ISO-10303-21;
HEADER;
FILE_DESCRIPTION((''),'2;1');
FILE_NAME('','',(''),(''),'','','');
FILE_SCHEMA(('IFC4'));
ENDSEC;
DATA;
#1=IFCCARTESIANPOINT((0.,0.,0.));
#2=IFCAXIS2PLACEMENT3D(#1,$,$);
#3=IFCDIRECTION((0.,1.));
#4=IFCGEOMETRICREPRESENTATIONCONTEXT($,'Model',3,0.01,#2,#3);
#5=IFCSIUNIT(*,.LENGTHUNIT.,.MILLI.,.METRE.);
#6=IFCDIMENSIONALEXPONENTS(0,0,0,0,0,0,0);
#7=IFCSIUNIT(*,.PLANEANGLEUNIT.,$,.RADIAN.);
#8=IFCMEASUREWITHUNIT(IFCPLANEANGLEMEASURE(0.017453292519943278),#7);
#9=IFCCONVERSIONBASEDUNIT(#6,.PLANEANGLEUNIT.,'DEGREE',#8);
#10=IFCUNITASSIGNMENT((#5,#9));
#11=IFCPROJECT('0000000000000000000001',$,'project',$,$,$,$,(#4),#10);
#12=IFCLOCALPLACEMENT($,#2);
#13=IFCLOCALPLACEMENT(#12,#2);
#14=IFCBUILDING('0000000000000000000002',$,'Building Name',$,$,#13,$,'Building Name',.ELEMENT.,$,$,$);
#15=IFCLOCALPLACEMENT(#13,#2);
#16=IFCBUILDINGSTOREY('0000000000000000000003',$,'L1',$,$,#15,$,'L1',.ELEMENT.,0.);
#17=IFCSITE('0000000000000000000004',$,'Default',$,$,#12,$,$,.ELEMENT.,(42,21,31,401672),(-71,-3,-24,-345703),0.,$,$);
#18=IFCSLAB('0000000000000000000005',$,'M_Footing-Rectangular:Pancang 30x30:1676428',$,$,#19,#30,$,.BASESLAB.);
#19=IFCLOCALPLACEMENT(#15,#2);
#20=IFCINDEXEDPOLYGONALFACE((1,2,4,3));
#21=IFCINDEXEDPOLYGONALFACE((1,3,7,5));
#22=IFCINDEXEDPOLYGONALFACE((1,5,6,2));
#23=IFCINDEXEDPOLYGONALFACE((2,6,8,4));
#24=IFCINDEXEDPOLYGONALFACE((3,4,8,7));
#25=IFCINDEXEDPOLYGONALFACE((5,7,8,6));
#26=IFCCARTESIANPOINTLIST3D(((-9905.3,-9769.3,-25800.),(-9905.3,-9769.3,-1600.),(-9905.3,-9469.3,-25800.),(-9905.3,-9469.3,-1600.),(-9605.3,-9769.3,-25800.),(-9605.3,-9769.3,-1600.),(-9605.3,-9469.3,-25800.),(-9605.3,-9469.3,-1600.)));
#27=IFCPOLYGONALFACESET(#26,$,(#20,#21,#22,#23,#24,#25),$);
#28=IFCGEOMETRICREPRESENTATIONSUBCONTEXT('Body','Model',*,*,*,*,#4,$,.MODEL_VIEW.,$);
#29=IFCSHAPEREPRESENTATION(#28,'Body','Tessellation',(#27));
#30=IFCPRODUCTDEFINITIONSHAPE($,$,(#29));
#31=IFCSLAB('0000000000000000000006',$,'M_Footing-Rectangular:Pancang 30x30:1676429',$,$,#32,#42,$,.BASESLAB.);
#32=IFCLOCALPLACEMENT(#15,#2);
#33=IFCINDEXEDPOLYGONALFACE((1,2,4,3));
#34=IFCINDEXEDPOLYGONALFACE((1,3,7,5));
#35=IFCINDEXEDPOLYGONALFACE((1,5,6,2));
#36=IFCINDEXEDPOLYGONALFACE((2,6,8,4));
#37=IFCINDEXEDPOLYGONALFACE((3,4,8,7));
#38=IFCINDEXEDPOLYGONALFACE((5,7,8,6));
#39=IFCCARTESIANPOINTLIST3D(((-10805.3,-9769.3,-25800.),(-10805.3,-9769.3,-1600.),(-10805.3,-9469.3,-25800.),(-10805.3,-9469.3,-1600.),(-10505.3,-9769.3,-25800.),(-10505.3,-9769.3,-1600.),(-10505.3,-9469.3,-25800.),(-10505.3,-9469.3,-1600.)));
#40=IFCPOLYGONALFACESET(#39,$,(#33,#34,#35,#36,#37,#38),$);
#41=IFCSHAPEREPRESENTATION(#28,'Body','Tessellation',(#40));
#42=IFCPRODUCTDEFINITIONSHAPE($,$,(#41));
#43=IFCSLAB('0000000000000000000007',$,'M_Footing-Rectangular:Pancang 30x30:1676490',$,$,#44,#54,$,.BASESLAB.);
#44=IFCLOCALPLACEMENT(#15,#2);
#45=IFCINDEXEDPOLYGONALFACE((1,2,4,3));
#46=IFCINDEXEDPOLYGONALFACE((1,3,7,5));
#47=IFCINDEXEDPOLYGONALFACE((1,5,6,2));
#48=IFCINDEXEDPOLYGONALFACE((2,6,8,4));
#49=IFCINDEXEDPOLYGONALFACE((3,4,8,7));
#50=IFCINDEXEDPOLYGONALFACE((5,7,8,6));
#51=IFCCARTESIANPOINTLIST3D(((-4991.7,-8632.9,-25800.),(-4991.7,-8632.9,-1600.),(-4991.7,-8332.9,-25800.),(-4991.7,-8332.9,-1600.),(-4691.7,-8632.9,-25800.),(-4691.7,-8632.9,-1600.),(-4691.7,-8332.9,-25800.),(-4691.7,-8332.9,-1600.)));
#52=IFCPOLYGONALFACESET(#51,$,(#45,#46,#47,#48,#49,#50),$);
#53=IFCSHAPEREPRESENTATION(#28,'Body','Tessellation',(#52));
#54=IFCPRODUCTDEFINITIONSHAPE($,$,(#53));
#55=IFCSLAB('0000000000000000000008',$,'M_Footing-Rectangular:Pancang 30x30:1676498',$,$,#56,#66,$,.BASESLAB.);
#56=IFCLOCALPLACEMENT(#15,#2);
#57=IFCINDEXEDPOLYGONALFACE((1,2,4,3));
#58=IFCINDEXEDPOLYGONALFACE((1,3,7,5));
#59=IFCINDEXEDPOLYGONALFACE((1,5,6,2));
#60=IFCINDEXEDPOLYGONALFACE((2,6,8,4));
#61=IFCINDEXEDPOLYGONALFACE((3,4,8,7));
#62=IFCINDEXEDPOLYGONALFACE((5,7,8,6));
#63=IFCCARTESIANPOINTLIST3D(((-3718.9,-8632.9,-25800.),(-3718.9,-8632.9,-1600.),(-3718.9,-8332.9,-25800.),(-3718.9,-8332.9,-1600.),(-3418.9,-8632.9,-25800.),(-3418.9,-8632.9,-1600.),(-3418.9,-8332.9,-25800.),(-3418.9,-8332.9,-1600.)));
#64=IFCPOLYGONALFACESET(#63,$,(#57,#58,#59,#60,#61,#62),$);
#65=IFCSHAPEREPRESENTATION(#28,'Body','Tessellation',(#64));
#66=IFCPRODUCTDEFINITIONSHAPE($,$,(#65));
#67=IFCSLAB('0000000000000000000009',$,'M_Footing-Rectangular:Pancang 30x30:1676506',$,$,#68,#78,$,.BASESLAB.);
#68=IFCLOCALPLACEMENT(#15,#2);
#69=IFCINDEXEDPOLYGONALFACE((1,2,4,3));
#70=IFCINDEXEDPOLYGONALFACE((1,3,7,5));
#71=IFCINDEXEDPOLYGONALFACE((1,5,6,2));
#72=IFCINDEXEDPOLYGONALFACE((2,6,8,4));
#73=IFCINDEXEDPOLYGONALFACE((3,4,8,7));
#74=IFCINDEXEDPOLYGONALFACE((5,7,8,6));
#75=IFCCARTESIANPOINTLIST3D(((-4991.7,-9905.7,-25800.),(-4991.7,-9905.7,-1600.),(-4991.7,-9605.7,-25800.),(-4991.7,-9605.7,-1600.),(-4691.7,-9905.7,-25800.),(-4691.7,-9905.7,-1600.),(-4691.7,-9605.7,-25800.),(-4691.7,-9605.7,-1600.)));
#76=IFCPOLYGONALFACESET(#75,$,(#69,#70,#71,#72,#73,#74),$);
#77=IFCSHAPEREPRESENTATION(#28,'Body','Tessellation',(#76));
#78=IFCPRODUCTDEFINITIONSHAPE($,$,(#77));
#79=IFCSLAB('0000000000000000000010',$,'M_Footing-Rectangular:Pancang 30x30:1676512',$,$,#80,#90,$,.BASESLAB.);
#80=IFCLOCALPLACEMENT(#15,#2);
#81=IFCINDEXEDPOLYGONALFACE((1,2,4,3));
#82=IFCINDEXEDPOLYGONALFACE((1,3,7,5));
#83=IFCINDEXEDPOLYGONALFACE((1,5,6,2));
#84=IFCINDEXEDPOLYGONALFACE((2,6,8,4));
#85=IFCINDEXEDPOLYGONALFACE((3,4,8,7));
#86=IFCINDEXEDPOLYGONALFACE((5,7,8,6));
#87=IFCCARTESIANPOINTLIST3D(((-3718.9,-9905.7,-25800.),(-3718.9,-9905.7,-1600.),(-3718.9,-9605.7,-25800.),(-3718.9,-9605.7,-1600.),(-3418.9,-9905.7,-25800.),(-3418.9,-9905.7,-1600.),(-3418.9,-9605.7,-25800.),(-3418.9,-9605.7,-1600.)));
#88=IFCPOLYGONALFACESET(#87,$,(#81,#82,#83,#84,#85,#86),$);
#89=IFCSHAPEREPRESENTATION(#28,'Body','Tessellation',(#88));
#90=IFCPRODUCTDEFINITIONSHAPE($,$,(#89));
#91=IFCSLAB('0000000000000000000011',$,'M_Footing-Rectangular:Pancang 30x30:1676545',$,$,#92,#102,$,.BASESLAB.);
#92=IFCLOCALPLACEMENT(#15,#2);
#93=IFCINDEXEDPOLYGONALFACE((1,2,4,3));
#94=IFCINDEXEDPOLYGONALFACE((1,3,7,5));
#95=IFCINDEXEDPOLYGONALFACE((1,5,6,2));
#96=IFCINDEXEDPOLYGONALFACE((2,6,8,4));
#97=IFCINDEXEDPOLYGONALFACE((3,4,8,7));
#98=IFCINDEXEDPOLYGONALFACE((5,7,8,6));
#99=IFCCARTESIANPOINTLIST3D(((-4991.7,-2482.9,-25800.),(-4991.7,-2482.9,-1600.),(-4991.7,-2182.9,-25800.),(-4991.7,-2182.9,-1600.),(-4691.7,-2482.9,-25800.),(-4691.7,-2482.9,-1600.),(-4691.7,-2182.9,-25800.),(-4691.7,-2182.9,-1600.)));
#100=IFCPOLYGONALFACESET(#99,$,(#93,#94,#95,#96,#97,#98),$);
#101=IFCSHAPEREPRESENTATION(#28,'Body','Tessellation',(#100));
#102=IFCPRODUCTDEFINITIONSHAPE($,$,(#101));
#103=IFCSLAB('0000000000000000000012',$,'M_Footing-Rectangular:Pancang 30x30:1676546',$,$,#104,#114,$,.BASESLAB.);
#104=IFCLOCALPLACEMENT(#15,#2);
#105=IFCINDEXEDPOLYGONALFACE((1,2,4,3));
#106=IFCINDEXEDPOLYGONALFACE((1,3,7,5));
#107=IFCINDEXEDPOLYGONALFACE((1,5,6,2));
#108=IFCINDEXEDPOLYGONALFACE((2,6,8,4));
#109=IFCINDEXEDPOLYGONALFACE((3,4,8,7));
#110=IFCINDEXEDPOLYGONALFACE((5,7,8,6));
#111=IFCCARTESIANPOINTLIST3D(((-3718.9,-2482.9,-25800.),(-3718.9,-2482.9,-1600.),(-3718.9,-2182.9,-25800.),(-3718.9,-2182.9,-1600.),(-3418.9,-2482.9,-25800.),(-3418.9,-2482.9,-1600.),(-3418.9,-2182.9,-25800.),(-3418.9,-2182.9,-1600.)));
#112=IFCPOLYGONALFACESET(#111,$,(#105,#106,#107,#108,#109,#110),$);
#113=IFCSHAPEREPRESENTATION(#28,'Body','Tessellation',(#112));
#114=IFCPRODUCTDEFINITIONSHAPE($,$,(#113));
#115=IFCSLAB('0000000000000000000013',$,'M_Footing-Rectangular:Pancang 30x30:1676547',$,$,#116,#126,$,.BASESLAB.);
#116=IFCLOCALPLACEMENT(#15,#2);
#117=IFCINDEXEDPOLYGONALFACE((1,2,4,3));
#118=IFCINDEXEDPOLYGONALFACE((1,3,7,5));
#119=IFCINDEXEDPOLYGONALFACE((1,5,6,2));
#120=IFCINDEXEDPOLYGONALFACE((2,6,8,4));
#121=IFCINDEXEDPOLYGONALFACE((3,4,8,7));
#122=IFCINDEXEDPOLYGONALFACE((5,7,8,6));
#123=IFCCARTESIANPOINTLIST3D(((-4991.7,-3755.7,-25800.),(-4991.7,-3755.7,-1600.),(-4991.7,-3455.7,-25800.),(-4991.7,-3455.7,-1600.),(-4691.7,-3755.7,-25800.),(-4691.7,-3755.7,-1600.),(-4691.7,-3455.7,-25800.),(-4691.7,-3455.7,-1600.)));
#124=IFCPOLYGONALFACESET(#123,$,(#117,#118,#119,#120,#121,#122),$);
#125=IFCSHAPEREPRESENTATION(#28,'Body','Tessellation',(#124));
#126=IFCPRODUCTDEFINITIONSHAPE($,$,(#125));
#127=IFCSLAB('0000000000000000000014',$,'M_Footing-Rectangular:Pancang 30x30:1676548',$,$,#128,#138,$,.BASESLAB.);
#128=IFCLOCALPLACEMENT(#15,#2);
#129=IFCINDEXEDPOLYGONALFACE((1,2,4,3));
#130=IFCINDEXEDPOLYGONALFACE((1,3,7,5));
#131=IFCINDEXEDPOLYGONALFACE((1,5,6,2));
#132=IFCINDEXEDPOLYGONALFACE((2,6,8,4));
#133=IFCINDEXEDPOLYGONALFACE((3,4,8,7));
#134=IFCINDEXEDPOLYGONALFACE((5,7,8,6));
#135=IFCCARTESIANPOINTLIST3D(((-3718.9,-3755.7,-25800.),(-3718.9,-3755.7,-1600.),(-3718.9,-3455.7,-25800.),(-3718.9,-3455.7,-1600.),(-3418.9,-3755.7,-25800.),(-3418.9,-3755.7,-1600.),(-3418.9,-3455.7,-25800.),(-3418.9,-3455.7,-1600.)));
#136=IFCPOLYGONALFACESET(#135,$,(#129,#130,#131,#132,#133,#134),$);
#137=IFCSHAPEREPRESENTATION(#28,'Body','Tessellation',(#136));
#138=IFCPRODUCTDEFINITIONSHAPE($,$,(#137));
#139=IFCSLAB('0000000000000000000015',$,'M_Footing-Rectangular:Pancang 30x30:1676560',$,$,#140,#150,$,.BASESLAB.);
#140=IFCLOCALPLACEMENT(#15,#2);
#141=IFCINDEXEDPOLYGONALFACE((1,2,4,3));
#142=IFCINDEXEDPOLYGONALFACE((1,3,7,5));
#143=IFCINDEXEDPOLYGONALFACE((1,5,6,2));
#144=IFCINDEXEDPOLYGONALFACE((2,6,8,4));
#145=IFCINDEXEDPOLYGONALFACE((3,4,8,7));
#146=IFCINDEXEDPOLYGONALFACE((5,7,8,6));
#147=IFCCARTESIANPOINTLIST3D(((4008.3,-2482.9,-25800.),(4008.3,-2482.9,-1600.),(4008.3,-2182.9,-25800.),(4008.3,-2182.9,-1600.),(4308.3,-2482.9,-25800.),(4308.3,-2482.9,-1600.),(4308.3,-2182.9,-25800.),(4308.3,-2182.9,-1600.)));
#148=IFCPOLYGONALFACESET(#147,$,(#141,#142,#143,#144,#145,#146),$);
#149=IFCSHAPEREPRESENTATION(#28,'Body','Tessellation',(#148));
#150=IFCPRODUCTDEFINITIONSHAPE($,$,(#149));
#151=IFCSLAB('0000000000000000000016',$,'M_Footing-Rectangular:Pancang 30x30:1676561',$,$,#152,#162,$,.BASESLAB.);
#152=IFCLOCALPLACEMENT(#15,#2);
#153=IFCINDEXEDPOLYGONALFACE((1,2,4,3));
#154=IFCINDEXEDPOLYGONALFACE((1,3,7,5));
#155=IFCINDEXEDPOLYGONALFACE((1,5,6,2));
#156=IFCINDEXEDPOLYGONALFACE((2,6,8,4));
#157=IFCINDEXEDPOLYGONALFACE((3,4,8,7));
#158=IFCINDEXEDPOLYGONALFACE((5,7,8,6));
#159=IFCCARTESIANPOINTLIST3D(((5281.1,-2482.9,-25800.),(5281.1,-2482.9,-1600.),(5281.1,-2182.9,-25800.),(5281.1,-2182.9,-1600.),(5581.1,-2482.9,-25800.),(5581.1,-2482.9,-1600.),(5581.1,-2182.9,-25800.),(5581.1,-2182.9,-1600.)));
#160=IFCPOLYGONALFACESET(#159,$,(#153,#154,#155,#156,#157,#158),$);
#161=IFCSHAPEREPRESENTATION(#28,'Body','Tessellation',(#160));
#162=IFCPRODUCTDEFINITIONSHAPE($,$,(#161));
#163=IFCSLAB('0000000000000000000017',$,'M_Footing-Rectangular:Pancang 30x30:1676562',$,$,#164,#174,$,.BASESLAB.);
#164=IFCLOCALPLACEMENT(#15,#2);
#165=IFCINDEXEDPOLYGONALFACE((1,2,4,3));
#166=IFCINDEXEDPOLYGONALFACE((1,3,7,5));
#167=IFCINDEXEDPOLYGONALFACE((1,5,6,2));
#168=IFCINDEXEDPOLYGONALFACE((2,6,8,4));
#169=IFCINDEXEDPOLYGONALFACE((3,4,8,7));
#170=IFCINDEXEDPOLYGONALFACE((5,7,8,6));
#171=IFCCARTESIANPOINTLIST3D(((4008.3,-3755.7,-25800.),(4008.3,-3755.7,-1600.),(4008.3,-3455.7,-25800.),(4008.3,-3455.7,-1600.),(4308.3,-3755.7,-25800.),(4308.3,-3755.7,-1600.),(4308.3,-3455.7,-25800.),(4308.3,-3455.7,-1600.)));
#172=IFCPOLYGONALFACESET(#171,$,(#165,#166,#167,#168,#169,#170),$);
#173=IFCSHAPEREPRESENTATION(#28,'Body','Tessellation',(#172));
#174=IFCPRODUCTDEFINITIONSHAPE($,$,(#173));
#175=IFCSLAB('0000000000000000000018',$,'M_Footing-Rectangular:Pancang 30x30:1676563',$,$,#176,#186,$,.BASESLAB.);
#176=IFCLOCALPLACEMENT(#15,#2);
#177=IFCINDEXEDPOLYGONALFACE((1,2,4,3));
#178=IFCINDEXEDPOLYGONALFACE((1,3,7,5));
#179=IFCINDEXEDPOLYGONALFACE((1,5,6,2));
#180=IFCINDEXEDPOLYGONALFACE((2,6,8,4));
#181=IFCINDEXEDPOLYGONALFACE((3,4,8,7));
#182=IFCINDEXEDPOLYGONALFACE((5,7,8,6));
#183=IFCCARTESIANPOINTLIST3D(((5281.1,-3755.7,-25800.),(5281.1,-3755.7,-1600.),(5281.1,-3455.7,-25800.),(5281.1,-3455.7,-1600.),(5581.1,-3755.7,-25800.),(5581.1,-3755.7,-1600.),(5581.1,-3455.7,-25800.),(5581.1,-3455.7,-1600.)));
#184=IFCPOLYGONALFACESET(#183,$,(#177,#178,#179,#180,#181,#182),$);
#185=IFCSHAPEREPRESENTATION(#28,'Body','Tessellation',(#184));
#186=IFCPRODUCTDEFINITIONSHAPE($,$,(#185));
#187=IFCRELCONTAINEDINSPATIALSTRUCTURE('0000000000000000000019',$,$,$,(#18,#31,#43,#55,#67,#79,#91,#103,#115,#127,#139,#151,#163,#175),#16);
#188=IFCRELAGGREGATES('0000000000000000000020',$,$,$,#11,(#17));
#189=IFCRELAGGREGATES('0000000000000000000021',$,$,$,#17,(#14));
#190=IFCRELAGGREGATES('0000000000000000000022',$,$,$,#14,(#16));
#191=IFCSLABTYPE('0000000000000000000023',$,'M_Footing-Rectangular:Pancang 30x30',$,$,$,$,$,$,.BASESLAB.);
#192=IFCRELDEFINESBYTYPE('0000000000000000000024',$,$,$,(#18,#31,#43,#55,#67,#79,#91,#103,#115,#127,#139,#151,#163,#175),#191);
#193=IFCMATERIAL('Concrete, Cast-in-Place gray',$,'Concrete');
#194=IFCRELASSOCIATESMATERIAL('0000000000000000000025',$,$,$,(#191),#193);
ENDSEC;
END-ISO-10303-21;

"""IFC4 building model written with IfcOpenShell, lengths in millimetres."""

from ifc_helpers import new_model, entity, si_unit, converted_unit, direction, frame, origin, place, context, subcontext, project, spatial, indexed_curve, outline, extrude, material, type_object, element, save


model = new_model("IFC4")

# Units and contexts
model_context = context("Model", 3, precision=0.01, world=origin(), true_north=direction((0.0, 1.0)))
body_context = subcontext(model_context, "Body", "Model", "MODEL_VIEW")
ifc_project = project(units=[si_unit("LENGTHUNIT", "METRE", prefix="MILLI"), converted_unit("PLANEANGLEUNIT", "DEGREE", entity("IfcPlaneAngleMeasure", 0.017453292519943278), si_unit("PLANEANGLEUNIT", "RADIAN"), dimensions=[0, 0, 0, 0, 0, 0, 0])], contexts=[model_context])

# Site, building, storey
site_placement = place(None, origin())
site = spatial("IfcSite", under=ifc_project, at=site_placement, Name="Default", CompositionType="ELEMENT", RefLatitude=(42, 21, 31, 401672), RefLongitude=(-71, -3, -24, -345703), RefElevation=0.0)
building_placement = place(site_placement, origin())
building = spatial("IfcBuilding", under=site, at=building_placement, Name="Building Name", LongName="Building Name", CompositionType="ELEMENT")
storey_placement = place(building_placement, origin())
storey = spatial("IfcBuildingStorey", under=building, at=storey_placement, Name="L1", LongName="L1", CompositionType="ELEMENT", Elevation=0.0)

# Slabs
ifc_material = material(Name="Concrete, Cast-in-Place gray", Category="Concrete")
slab_type = type_object("IfcSlabType", Name="M_Footing-Rectangular:Pancang 30x30", PredefinedType="BASESLAB", material=ifc_material)
slab_1_placement = place(storey_placement, origin())
element("IfcSlab", 1, at=slab_1_placement, inside=storey, type_object=slab_type, Name="M_Footing-Rectangular:Pancang 30x30:1676428", PredefinedType="BASESLAB", context=body_context, shape_type="SweptSolid", body=[
    extrude(outline(indexed_curve([(-150.0, -150.0), (150.0, -150.0), (150.0, 150.0), (-150.0, 150.0), (-150.0, -150.0)], self_intersect=False)), frame((-9755.3, -9619.3, -25800.0), z_axis=(0.0, 0.0, 1.0), x_axis=(-1.0, 0.0, 0.0)), (0.0, 0.0, 1.0), 24200.0),
])
slab_2_placement = place(storey_placement, origin())
element("IfcSlab", 2, at=slab_2_placement, inside=storey, type_object=slab_type, Name="M_Footing-Rectangular:Pancang 30x30:1676429", PredefinedType="BASESLAB", context=body_context, shape_type="SweptSolid", body=[
    extrude(outline(indexed_curve([(-150.0, -150.0), (150.0, -150.0), (150.0, 150.0), (-150.0, 150.0), (-150.0, -150.0)], self_intersect=False)), frame((-10655.3, -9619.3, -25800.0), z_axis=(0.0, 0.0, 1.0), x_axis=(-1.0, 0.0, 0.0)), (0.0, 0.0, 1.0), 24200.0),
])
slab_3_placement = place(storey_placement, origin())
element("IfcSlab", 3, at=slab_3_placement, inside=storey, type_object=slab_type, Name="M_Footing-Rectangular:Pancang 30x30:1676490", PredefinedType="BASESLAB", context=body_context, shape_type="SweptSolid", body=[
    extrude(outline(indexed_curve([(-150.0, -150.0), (150.0, -150.0), (150.0, 150.0), (-150.0, 150.0), (-150.0, -150.0)], self_intersect=False)), frame((-4841.7, -8482.9, -25800.0), z_axis=(0.0, 0.0, 1.0), x_axis=(-1.0, 0.0, 0.0)), (0.0, 0.0, 1.0), 24200.0),
])
slab_4_placement = place(storey_placement, origin())
element("IfcSlab", 4, at=slab_4_placement, inside=storey, type_object=slab_type, Name="M_Footing-Rectangular:Pancang 30x30:1676498", PredefinedType="BASESLAB", context=body_context, shape_type="SweptSolid", body=[
    extrude(outline(indexed_curve([(-150.0, -150.0), (150.0, -150.0), (150.0, 150.0), (-150.0, 150.0), (-150.0, -150.0)], self_intersect=False)), frame((-3568.9, -8482.9, -25800.0), z_axis=(0.0, 0.0, 1.0), x_axis=(-1.0, 0.0, 0.0)), (0.0, 0.0, 1.0), 24200.0),
])
slab_5_placement = place(storey_placement, origin())
element("IfcSlab", 5, at=slab_5_placement, inside=storey, type_object=slab_type, Name="M_Footing-Rectangular:Pancang 30x30:1676506", PredefinedType="BASESLAB", context=body_context, shape_type="SweptSolid", body=[
    extrude(outline(indexed_curve([(-150.0, -150.0), (150.0, -150.0), (150.0, 150.0), (-150.0, 150.0), (-150.0, -150.0)], self_intersect=False)), frame((-4841.7, -9755.7, -25800.0), z_axis=(0.0, 0.0, 1.0), x_axis=(-1.0, 0.0, 0.0)), (0.0, 0.0, 1.0), 24200.0),
])
slab_6_placement = place(storey_placement, origin())
element("IfcSlab", 6, at=slab_6_placement, inside=storey, type_object=slab_type, Name="M_Footing-Rectangular:Pancang 30x30:1676512", PredefinedType="BASESLAB", context=body_context, shape_type="SweptSolid", body=[
    extrude(outline(indexed_curve([(-150.0, -150.0), (150.0, -150.0), (150.0, 150.0), (-150.0, 150.0), (-150.0, -150.0)], self_intersect=False)), frame((-3568.9, -9755.7, -25800.0), z_axis=(0.0, 0.0, 1.0), x_axis=(-1.0, 0.0, 0.0)), (0.0, 0.0, 1.0), 24200.0),
])
slab_7_placement = place(storey_placement, origin())
element("IfcSlab", 7, at=slab_7_placement, inside=storey, type_object=slab_type, Name="M_Footing-Rectangular:Pancang 30x30:1676545", PredefinedType="BASESLAB", context=body_context, shape_type="SweptSolid", body=[
    extrude(outline(indexed_curve([(-150.0, -150.0), (150.0, -150.0), (150.0, 150.0), (-150.0, 150.0), (-150.0, -150.0)], self_intersect=False)), frame((-4841.7, -2332.9, -25800.0), z_axis=(0.0, 0.0, 1.0), x_axis=(-1.0, 0.0, 0.0)), (0.0, 0.0, 1.0), 24200.0),
])
slab_8_placement = place(storey_placement, origin())
element("IfcSlab", 8, at=slab_8_placement, inside=storey, type_object=slab_type, Name="M_Footing-Rectangular:Pancang 30x30:1676546", PredefinedType="BASESLAB", context=body_context, shape_type="SweptSolid", body=[
    extrude(outline(indexed_curve([(-150.0, -150.0), (150.0, -150.0), (150.0, 150.0), (-150.0, 150.0), (-150.0, -150.0)], self_intersect=False)), frame((-3568.9, -2332.9, -25800.0), z_axis=(0.0, 0.0, 1.0), x_axis=(-1.0, 0.0, 0.0)), (0.0, 0.0, 1.0), 24200.0),
])
slab_9_placement = place(storey_placement, origin())
element("IfcSlab", 9, at=slab_9_placement, inside=storey, type_object=slab_type, Name="M_Footing-Rectangular:Pancang 30x30:1676547", PredefinedType="BASESLAB", context=body_context, shape_type="SweptSolid", body=[
    extrude(outline(indexed_curve([(-150.0, -150.0), (150.0, -150.0), (150.0, 150.0), (-150.0, 150.0), (-150.0, -150.0)], self_intersect=False)), frame((-4841.7, -3605.7, -25800.0), z_axis=(0.0, 0.0, 1.0), x_axis=(-1.0, 0.0, 0.0)), (0.0, 0.0, 1.0), 24200.0),
])
slab_10_placement = place(storey_placement, origin())
element("IfcSlab", 10, at=slab_10_placement, inside=storey, type_object=slab_type, Name="M_Footing-Rectangular:Pancang 30x30:1676548", PredefinedType="BASESLAB", context=body_context, shape_type="SweptSolid", body=[
    extrude(outline(indexed_curve([(-150.0, -150.0), (150.0, -150.0), (150.0, 150.0), (-150.0, 150.0), (-150.0, -150.0)], self_intersect=False)), frame((-3568.9, -3605.7, -25800.0), z_axis=(0.0, 0.0, 1.0), x_axis=(-1.0, 0.0, 0.0)), (0.0, 0.0, 1.0), 24200.0),
])
slab_11_placement = place(storey_placement, origin())
element("IfcSlab", 11, at=slab_11_placement, inside=storey, type_object=slab_type, Name="M_Footing-Rectangular:Pancang 30x30:1676560", PredefinedType="BASESLAB", context=body_context, shape_type="SweptSolid", body=[
    extrude(outline(indexed_curve([(-150.0, -150.0), (150.0, -150.0), (150.0, 150.0), (-150.0, 150.0), (-150.0, -150.0)], self_intersect=False)), frame((4158.3, -2332.9, -25800.0), z_axis=(0.0, 0.0, 1.0), x_axis=(-1.0, 0.0, 0.0)), (0.0, 0.0, 1.0), 24200.0),
])
slab_12_placement = place(storey_placement, origin())
element("IfcSlab", 12, at=slab_12_placement, inside=storey, type_object=slab_type, Name="M_Footing-Rectangular:Pancang 30x30:1676561", PredefinedType="BASESLAB", context=body_context, shape_type="SweptSolid", body=[
    extrude(outline(indexed_curve([(-150.0, -150.0), (150.0, -150.0), (150.0, 150.0), (-150.0, 150.0), (-150.0, -150.0)], self_intersect=False)), frame((5431.1, -2332.9, -25800.0), z_axis=(0.0, 0.0, 1.0), x_axis=(-1.0, 0.0, 0.0)), (0.0, 0.0, 1.0), 24200.0),
])
slab_13_placement = place(storey_placement, origin())
element("IfcSlab", 13, at=slab_13_placement, inside=storey, type_object=slab_type, Name="M_Footing-Rectangular:Pancang 30x30:1676562", PredefinedType="BASESLAB", context=body_context, shape_type="SweptSolid", body=[
    extrude(outline(indexed_curve([(-150.0, -150.0), (150.0, -150.0), (150.0, 150.0), (-150.0, 150.0), (-150.0, -150.0)], self_intersect=False)), frame((4158.3, -3605.7, -25800.0), z_axis=(0.0, 0.0, 1.0), x_axis=(-1.0, 0.0, 0.0)), (0.0, 0.0, 1.0), 24200.0),
])
slab_14_placement = place(storey_placement, origin())
element("IfcSlab", 14, at=slab_14_placement, inside=storey, type_object=slab_type, Name="M_Footing-Rectangular:Pancang 30x30:1676563", PredefinedType="BASESLAB", context=body_context, shape_type="SweptSolid", body=[
    extrude(outline(indexed_curve([(-150.0, -150.0), (150.0, -150.0), (150.0, 150.0), (-150.0, 150.0), (-150.0, -150.0)], self_intersect=False)), frame((5431.1, -3605.7, -25800.0), z_axis=(0.0, 0.0, 1.0), x_axis=(-1.0, 0.0, 0.0)), (0.0, 0.0, 1.0), 24200.0),
])

save(model, "model.ifc")
